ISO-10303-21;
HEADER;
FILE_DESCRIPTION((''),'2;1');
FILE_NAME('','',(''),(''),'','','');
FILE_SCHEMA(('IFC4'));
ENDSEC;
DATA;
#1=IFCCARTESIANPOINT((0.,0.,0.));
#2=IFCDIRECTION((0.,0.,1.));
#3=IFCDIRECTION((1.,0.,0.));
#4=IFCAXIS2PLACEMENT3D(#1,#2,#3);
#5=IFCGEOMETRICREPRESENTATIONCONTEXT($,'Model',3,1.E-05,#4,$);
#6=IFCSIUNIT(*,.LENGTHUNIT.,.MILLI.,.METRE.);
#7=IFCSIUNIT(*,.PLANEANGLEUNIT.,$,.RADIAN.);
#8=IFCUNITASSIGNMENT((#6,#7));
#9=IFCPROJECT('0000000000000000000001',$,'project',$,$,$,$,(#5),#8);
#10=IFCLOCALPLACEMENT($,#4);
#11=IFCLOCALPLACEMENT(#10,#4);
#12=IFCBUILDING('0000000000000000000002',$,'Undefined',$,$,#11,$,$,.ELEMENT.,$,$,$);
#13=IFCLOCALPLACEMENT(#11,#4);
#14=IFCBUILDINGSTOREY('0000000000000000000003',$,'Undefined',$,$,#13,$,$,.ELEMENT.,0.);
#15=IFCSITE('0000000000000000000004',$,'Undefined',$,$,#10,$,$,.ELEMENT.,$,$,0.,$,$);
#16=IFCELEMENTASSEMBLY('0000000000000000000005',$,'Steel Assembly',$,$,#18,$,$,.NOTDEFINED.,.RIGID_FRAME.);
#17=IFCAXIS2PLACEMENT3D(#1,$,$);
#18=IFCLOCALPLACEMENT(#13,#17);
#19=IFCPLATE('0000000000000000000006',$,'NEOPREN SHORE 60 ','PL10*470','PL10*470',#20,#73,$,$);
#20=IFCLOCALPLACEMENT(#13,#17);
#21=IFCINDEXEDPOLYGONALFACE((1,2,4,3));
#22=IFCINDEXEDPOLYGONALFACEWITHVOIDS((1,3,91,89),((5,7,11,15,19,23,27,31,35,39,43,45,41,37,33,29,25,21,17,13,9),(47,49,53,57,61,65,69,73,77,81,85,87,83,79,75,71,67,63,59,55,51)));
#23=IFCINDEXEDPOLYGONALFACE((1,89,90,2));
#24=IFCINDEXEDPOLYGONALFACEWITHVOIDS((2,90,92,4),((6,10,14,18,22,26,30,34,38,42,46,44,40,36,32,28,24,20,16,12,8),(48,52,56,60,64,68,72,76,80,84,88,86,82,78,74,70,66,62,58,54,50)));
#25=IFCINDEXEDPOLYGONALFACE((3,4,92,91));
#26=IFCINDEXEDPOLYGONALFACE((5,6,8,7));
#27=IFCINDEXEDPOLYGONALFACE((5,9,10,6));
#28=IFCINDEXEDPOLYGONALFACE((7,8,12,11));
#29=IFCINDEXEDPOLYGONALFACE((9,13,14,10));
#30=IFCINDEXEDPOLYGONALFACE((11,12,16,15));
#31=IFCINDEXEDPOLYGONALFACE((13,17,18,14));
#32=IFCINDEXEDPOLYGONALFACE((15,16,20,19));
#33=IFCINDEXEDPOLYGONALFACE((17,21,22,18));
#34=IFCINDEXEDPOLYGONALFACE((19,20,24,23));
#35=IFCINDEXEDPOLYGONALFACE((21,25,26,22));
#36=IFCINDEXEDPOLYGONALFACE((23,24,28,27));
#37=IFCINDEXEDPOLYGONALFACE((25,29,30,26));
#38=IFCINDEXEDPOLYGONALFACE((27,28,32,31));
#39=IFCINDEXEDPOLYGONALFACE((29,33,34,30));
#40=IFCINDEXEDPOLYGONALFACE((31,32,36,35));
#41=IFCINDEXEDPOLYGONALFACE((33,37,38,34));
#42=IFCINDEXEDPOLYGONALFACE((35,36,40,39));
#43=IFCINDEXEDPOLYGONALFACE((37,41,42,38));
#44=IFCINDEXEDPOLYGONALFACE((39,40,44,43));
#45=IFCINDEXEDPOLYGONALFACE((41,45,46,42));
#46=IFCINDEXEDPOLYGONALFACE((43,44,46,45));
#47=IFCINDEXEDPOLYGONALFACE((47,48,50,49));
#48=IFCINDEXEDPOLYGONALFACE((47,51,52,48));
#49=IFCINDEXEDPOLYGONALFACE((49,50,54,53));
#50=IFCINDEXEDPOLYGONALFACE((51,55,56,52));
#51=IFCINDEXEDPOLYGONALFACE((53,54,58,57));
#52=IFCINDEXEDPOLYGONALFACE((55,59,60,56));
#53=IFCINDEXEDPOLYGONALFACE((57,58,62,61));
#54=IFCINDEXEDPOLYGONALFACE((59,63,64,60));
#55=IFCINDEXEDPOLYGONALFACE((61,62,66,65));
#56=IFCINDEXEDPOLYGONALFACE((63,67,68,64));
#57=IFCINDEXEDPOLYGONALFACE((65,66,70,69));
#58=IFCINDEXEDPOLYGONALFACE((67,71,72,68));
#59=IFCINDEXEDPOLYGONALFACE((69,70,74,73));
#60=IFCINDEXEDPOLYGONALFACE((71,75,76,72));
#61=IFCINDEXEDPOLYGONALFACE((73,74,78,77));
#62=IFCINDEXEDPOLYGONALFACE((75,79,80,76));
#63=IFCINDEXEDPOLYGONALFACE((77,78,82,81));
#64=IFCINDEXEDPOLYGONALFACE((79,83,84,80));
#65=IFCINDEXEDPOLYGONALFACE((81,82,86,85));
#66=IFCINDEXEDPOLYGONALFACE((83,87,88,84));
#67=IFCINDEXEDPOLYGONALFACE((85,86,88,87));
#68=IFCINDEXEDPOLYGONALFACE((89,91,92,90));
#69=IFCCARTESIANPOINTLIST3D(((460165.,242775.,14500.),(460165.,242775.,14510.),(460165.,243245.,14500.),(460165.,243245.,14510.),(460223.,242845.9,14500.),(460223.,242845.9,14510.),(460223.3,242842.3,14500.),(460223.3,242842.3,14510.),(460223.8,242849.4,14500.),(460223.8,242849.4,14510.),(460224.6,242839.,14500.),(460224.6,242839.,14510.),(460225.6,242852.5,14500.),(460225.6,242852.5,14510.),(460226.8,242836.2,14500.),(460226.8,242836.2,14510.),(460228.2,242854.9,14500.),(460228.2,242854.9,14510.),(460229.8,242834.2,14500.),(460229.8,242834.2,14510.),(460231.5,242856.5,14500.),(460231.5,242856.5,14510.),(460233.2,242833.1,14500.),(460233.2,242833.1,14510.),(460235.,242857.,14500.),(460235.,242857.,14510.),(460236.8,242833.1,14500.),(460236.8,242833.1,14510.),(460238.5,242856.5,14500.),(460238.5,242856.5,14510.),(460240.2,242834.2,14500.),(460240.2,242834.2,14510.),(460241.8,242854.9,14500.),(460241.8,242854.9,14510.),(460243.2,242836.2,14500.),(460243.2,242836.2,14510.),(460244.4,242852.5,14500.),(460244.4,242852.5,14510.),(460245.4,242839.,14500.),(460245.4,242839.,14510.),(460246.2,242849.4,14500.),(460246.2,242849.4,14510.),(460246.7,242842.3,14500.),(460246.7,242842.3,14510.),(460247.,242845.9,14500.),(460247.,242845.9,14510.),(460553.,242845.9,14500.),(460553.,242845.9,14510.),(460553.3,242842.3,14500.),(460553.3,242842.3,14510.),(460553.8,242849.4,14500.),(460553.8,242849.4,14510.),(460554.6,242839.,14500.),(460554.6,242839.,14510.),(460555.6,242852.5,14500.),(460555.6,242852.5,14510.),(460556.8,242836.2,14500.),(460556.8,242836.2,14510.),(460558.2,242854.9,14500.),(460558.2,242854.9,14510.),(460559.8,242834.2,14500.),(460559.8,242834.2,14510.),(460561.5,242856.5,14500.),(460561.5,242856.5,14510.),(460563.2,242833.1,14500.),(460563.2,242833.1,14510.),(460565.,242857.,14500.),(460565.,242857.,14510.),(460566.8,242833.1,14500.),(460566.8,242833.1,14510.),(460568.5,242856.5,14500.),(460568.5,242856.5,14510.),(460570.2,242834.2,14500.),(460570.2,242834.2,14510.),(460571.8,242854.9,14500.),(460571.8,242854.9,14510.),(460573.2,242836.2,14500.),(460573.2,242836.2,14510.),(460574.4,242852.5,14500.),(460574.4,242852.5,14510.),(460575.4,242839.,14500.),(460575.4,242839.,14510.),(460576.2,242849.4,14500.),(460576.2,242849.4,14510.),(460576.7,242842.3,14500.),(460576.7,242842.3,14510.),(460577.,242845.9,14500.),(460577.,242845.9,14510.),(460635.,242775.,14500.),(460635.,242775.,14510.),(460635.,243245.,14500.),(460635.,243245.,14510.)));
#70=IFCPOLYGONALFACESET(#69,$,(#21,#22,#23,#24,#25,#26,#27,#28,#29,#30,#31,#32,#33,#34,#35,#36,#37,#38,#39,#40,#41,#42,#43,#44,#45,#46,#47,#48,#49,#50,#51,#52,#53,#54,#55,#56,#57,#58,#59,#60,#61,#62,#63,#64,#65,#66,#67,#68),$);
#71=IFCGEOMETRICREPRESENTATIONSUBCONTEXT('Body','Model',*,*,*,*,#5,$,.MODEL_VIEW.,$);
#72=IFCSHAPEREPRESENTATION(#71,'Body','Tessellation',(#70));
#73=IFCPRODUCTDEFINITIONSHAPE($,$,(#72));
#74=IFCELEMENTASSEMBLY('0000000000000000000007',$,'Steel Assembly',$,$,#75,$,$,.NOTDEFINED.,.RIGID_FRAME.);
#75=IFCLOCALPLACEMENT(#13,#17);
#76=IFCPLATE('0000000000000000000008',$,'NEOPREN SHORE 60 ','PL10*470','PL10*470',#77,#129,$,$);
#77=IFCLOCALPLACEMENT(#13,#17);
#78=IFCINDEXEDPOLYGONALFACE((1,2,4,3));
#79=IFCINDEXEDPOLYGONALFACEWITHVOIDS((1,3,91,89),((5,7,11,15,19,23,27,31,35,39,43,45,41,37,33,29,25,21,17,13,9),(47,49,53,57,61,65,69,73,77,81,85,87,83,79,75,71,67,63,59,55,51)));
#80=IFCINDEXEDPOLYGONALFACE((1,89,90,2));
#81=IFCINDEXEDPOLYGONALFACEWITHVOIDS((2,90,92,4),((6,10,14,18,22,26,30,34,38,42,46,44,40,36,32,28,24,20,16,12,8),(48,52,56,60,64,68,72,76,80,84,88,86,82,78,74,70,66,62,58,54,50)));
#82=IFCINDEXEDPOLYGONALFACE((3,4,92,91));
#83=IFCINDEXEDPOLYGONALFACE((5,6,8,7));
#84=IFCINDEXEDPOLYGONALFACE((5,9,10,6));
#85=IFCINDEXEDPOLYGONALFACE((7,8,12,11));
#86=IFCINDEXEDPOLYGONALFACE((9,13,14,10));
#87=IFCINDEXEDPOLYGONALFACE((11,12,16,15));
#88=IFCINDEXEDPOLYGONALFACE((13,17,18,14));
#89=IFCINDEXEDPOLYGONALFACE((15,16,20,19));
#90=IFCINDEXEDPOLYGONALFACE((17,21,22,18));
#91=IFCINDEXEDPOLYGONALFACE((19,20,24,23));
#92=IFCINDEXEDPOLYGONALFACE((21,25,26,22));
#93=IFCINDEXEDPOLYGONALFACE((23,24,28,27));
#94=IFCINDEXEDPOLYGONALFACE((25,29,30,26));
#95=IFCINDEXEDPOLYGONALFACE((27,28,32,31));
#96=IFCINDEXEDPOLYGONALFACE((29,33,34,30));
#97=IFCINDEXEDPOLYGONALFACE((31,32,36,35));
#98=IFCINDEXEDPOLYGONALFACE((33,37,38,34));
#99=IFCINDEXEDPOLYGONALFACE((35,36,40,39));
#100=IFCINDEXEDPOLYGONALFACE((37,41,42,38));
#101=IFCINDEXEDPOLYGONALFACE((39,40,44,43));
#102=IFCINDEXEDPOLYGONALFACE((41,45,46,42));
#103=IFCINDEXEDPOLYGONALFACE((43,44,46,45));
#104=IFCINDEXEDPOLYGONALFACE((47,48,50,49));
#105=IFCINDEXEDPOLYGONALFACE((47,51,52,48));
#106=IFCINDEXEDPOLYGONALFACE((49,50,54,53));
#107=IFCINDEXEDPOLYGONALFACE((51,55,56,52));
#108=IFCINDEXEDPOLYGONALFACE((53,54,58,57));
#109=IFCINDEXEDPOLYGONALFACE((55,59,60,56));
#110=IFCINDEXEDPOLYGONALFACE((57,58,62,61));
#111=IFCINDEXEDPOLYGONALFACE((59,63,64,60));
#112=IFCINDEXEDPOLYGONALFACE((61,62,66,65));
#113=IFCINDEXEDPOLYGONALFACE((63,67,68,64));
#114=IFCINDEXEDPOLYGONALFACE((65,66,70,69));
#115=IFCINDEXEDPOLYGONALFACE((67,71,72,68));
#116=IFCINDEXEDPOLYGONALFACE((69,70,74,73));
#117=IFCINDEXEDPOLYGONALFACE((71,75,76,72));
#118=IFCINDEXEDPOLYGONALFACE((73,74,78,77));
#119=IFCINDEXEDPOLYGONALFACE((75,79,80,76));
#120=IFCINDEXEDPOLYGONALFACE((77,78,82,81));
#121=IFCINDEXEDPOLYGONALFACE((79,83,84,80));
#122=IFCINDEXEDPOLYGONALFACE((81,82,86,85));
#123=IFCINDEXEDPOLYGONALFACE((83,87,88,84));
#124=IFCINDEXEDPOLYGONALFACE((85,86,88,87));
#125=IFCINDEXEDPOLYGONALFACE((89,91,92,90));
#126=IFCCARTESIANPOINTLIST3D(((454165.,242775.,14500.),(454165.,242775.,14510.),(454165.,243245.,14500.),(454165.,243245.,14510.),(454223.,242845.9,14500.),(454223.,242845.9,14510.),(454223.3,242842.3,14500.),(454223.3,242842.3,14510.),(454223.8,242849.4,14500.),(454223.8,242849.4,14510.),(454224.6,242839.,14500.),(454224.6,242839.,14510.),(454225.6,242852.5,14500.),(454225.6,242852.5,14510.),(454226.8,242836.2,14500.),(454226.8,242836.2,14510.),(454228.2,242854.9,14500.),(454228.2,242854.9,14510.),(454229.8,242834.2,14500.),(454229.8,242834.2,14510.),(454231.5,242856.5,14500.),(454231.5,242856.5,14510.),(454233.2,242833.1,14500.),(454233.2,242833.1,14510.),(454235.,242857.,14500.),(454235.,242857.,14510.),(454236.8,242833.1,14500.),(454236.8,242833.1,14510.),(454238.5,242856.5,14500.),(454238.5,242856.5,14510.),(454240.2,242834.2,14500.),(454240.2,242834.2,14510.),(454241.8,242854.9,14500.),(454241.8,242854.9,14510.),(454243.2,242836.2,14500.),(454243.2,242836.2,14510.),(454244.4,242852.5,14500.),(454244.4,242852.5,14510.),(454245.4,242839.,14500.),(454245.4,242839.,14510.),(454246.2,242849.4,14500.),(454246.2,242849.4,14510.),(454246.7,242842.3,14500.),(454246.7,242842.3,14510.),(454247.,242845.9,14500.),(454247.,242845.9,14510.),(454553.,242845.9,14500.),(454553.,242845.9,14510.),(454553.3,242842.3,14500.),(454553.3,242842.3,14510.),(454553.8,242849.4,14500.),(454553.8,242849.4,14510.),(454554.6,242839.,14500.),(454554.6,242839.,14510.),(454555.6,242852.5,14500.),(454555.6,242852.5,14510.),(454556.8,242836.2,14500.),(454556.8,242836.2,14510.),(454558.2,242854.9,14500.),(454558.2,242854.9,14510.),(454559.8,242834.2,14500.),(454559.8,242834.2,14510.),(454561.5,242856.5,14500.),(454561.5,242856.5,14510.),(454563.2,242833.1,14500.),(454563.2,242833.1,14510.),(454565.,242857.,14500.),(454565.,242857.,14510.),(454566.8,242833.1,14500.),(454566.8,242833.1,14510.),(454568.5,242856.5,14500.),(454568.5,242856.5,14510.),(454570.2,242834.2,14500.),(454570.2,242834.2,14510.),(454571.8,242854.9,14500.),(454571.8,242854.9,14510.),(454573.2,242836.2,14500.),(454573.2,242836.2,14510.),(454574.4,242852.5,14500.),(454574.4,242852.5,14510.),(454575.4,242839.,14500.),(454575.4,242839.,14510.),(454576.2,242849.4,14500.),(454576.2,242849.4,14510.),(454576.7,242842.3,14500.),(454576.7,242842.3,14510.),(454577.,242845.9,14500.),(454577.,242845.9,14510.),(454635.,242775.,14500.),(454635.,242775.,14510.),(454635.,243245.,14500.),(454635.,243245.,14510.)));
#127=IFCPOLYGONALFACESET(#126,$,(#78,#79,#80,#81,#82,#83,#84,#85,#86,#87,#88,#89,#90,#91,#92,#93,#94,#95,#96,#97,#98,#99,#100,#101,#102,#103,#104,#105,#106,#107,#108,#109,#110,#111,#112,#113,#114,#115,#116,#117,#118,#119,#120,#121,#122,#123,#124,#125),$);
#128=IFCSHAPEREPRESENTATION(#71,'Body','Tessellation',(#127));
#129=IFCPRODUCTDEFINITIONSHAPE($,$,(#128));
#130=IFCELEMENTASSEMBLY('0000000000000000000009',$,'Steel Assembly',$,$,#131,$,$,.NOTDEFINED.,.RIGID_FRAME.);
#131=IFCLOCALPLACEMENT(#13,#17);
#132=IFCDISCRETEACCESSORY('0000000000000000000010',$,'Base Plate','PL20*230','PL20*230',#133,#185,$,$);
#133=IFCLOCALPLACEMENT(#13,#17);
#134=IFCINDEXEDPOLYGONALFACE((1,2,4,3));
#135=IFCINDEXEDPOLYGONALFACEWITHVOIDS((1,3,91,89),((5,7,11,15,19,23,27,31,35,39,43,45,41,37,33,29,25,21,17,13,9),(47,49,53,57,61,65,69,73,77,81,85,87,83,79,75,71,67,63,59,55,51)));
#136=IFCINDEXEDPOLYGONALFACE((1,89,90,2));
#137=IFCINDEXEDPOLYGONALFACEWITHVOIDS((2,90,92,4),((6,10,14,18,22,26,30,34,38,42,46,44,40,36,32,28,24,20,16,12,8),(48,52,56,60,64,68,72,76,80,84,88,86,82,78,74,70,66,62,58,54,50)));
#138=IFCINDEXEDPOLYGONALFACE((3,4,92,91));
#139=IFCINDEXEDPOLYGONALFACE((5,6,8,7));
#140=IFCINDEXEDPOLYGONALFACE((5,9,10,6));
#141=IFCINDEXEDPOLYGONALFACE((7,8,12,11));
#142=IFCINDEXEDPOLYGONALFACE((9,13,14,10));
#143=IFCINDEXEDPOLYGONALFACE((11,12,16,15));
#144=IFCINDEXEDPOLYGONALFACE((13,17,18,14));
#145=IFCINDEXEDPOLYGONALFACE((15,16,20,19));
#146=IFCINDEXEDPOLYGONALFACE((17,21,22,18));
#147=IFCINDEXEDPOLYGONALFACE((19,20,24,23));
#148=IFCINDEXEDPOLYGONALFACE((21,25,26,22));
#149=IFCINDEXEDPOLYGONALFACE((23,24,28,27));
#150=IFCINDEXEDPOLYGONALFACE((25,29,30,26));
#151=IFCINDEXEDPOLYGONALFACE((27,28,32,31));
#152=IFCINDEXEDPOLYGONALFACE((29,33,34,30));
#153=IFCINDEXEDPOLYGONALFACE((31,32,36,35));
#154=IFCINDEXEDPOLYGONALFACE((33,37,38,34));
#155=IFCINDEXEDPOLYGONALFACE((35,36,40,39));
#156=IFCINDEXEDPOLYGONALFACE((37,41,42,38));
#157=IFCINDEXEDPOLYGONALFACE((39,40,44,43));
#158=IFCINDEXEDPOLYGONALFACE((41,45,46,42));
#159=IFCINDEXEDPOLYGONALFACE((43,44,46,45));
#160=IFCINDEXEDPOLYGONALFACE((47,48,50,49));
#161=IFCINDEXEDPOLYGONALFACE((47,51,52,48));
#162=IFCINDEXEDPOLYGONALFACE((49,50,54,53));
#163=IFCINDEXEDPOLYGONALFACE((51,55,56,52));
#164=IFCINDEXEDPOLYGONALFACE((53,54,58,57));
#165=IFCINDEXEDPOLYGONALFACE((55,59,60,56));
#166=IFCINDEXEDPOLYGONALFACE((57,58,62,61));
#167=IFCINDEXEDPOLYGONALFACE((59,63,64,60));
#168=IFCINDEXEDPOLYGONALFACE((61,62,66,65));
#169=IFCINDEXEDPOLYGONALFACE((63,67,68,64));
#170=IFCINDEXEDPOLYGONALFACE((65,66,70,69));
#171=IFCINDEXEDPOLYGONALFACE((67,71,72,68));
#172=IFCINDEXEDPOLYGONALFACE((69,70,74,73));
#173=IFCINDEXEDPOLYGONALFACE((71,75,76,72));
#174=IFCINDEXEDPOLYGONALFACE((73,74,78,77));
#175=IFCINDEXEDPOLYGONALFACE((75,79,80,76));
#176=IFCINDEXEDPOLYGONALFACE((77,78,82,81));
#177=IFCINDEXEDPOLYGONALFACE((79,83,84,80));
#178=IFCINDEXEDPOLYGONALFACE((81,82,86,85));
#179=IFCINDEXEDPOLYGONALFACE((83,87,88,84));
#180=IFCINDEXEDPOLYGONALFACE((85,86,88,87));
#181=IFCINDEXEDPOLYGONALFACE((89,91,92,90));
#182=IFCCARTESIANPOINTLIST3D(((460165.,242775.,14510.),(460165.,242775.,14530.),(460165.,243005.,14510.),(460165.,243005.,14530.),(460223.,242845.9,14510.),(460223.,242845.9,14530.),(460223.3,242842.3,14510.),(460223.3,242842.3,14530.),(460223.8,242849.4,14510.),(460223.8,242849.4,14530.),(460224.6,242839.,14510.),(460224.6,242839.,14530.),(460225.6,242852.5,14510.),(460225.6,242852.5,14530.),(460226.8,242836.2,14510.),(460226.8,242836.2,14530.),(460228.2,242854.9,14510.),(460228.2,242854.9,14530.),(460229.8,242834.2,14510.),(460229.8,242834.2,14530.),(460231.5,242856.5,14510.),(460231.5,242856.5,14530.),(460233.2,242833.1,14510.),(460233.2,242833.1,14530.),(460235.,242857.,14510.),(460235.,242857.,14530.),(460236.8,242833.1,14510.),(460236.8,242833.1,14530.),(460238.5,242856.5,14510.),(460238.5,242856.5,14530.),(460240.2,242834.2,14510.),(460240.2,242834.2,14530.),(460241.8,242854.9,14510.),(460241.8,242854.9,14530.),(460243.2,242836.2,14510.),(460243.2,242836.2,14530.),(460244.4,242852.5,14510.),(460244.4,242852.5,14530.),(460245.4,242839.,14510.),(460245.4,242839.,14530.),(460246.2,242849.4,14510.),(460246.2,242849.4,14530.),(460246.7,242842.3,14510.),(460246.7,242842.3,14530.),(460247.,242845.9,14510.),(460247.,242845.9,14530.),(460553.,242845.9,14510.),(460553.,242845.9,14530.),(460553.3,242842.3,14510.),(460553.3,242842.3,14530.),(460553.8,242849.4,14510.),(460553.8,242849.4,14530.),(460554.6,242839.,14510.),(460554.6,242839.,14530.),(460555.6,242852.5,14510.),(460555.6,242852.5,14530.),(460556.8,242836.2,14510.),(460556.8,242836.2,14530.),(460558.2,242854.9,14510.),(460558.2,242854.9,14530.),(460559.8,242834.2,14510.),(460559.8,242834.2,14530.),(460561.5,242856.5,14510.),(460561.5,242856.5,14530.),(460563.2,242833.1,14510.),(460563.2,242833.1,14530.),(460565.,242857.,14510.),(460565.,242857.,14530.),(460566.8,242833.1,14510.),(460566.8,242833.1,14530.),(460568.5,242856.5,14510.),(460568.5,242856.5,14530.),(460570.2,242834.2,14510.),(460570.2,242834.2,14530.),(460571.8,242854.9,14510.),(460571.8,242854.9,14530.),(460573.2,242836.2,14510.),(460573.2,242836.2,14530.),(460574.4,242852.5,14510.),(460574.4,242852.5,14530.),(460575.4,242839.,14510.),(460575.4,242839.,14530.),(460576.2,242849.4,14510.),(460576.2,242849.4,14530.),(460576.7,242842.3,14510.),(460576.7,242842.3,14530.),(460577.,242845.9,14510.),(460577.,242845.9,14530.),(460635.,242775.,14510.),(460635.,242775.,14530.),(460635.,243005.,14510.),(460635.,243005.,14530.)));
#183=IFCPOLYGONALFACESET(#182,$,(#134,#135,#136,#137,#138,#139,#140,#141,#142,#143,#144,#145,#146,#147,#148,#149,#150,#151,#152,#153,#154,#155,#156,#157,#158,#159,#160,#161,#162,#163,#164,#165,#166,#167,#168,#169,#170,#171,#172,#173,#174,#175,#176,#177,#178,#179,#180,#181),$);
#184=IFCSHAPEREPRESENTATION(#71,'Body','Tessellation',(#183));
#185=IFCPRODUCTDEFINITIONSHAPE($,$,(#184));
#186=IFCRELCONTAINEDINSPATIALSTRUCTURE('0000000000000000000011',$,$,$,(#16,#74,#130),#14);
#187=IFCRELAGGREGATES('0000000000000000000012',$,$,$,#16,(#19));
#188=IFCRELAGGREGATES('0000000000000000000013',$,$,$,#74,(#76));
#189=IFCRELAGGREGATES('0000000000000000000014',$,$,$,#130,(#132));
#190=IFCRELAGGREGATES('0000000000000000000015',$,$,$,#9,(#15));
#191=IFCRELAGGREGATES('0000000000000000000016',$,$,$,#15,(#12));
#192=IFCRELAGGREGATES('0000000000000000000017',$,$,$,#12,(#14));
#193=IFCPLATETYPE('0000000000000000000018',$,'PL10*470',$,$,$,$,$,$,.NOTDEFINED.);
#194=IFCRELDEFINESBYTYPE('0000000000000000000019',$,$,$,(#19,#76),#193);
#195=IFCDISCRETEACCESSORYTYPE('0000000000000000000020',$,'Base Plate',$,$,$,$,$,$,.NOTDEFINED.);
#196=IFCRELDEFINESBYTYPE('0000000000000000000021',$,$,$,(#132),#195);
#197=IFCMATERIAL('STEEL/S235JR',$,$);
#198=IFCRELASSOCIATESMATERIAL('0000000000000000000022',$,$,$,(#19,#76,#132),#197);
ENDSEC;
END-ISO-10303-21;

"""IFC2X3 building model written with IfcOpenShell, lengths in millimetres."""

from ifc_helpers import new_model, si_unit, frame, origin_with_axes, origin_2d_with_axis, place, context, subcontext, project, spatial, polyline, circle, outline, extrude, boolean, material, type_object, element, aggregate, save


model = new_model("IFC2X3")

# Units and contexts
model_context = context("Model", 3, precision=1e-05, world=origin_with_axes())
body_context = subcontext(model_context, "Body", "Model", "MODEL_VIEW")
ifc_project = project(units=[si_unit("LENGTHUNIT", "METRE", prefix="MILLI"), si_unit("PLANEANGLEUNIT", "RADIAN")], contexts=[model_context])

# Site, building, storey
site_placement = place(None, origin_with_axes())
site = spatial("IfcSite", under=ifc_project, at=site_placement, Name="Undefined", CompositionType="ELEMENT", RefElevation=0.0)
building_placement = place(site_placement, origin_with_axes())
building = spatial("IfcBuilding", under=site, at=building_placement, Name="Undefined", CompositionType="ELEMENT")
storey_placement = place(building_placement, origin_with_axes())
storey = spatial("IfcBuildingStorey", under=building, at=storey_placement, Name="Undefined", CompositionType="ELEMENT", Elevation=0.0)

# Shared definitions
ifc_material_1 = material(Name="STEEL/S235JR")

# Element assemblies, plates
assembly_1_placement = place(storey_placement, origin_with_axes())
assembly_1 = element("IfcElementAssembly", 1, at=assembly_1_placement, inside=storey, Name="Steel Assembly", AssemblyPlace="NOTDEFINED", PredefinedType="RIGID_FRAME")
plate_type = type_object("IfcPlateType", Name="PL10*470", PredefinedType="NOTDEFINED")
plate_1_placement = place(assembly_1_placement, frame((460165.0, 242775.0, 14505.0), z_axis=(0.0, 0.0, 1.0), x_axis=(1.0, 0.0, 0.0)))
plate_1 = element("IfcPlate", 2, at=plate_1_placement, type_object=plate_type, material=ifc_material_1, Name="NEOPREN SHORE 60 ", Description="PL10*470", ObjectType="PL10*470", context=body_context, shape_type="CSG", body=[
    boolean("DIFFERENCE", boolean("DIFFERENCE", extrude(outline(polyline([(0.0, 0.0), (470.0, 0.0), (470.0, 470.0), (0.0, 470.0), (0.0, 0.0)])), frame((0.0, 0.0, -5.0), z_axis=(0.0, 0.0, 1.0), x_axis=(1.0, 0.0, 0.0)), (0.0, 0.0, 1.0), 10.0), extrude(circle(Radius=12.0, at=origin_2d_with_axis()), frame((400.0, 70.0, 95.0), z_axis=(0.0, 0.0, -1.0), x_axis=(0.0, 1.0, 0.0)), (0.0, 0.0, 1.0), 170.0)), extrude(circle(Radius=12.0, at=origin_2d_with_axis()), frame((70.0, 70.0, 95.0), z_axis=(0.0, 0.0, -1.0), x_axis=(0.0, 1.0, 0.0)), (0.0, 0.0, 1.0), 170.0)),
])
aggregate(assembly_1, [plate_1])
assembly_2_placement = place(storey_placement, origin_with_axes())
assembly_2 = element("IfcElementAssembly", 3, at=assembly_2_placement, inside=storey, Name="Steel Assembly", AssemblyPlace="NOTDEFINED", PredefinedType="RIGID_FRAME")
plate_2_placement = place(assembly_2_placement, frame((454165.0, 242775.0, 14505.0), z_axis=(0.0, 0.0, 1.0), x_axis=(1.0, 0.0, 0.0)))
plate_2 = element("IfcPlate", 4, at=plate_2_placement, type_object=plate_type, material=ifc_material_1, Name="NEOPREN SHORE 60 ", Description="PL10*470", ObjectType="PL10*470", context=body_context, shape_type="CSG", body=[
    boolean("DIFFERENCE", boolean("DIFFERENCE", extrude(outline(polyline([(0.0, 0.0), (470.0, 0.0), (470.0, 470.0), (0.0, 470.0), (0.0, 0.0)])), frame((0.0, 0.0, -5.0), z_axis=(0.0, 0.0, 1.0), x_axis=(1.0, 0.0, 0.0)), (0.0, 0.0, 1.0), 10.0), extrude(circle(Radius=12.0, at=origin_2d_with_axis()), frame((400.0, 70.0, 95.0), z_axis=(0.0, 0.0, -1.0), x_axis=(0.0, 1.0, 0.0)), (0.0, 0.0, 1.0), 170.0)), extrude(circle(Radius=12.0, at=origin_2d_with_axis()), frame((70.0, 70.0, 95.0), z_axis=(0.0, 0.0, -1.0), x_axis=(0.0, 1.0, 0.0)), (0.0, 0.0, 1.0), 170.0)),
])
aggregate(assembly_2, [plate_2])

# Element assembly
assembly_3_placement = place(storey_placement, origin_with_axes())
assembly_3 = element("IfcElementAssembly", 5, at=assembly_3_placement, inside=storey, Name="Steel Assembly", AssemblyPlace="NOTDEFINED", PredefinedType="RIGID_FRAME")

# Discrete accessory
discrete_accessory_type_1 = type_object("IfcDiscreteAccessoryType", Name="Base Plate")
discrete_accessory_1_placement = place(assembly_3_placement, frame((460165.0, 243005.0, 14520.0), z_axis=(0.0, 0.0, -1.0), x_axis=(1.0, 0.0, 0.0)))
discrete_accessory_1 = element("IfcDiscreteAccessory", 6, at=discrete_accessory_1_placement, type_object=discrete_accessory_type_1, material=ifc_material_1, Name="Base Plate", Description="PL20*230", ObjectType="PL20*230", context=body_context, shape_type="CSG", body=[
    boolean("DIFFERENCE", boolean("DIFFERENCE", extrude(outline(polyline([(0.0, 0.0), (470.0, 0.0), (470.0, 230.0), (0.0, 230.0), (0.0, 0.0)])), frame((0.0, 0.0, -10.0), z_axis=(0.0, 0.0, 1.0), x_axis=(1.0, 0.0, 0.0)), (0.0, 0.0, 1.0), 20.0), extrude(circle(Radius=12.0, at=origin_2d_with_axis()), frame((70.0, 160.0, -80.0), z_axis=(0.0, 0.0, 1.0), x_axis=(0.0, -1.0, 0.0)), (0.0, 0.0, 1.0), 170.0)), extrude(circle(Radius=12.0, at=origin_2d_with_axis()), frame((400.0, 160.0, -80.0), z_axis=(0.0, 0.0, 1.0), x_axis=(0.0, -1.0, 0.0)), (0.0, 0.0, 1.0), 170.0)),
])
aggregate(assembly_3, [discrete_accessory_1])

save(model, "model.ifc")
